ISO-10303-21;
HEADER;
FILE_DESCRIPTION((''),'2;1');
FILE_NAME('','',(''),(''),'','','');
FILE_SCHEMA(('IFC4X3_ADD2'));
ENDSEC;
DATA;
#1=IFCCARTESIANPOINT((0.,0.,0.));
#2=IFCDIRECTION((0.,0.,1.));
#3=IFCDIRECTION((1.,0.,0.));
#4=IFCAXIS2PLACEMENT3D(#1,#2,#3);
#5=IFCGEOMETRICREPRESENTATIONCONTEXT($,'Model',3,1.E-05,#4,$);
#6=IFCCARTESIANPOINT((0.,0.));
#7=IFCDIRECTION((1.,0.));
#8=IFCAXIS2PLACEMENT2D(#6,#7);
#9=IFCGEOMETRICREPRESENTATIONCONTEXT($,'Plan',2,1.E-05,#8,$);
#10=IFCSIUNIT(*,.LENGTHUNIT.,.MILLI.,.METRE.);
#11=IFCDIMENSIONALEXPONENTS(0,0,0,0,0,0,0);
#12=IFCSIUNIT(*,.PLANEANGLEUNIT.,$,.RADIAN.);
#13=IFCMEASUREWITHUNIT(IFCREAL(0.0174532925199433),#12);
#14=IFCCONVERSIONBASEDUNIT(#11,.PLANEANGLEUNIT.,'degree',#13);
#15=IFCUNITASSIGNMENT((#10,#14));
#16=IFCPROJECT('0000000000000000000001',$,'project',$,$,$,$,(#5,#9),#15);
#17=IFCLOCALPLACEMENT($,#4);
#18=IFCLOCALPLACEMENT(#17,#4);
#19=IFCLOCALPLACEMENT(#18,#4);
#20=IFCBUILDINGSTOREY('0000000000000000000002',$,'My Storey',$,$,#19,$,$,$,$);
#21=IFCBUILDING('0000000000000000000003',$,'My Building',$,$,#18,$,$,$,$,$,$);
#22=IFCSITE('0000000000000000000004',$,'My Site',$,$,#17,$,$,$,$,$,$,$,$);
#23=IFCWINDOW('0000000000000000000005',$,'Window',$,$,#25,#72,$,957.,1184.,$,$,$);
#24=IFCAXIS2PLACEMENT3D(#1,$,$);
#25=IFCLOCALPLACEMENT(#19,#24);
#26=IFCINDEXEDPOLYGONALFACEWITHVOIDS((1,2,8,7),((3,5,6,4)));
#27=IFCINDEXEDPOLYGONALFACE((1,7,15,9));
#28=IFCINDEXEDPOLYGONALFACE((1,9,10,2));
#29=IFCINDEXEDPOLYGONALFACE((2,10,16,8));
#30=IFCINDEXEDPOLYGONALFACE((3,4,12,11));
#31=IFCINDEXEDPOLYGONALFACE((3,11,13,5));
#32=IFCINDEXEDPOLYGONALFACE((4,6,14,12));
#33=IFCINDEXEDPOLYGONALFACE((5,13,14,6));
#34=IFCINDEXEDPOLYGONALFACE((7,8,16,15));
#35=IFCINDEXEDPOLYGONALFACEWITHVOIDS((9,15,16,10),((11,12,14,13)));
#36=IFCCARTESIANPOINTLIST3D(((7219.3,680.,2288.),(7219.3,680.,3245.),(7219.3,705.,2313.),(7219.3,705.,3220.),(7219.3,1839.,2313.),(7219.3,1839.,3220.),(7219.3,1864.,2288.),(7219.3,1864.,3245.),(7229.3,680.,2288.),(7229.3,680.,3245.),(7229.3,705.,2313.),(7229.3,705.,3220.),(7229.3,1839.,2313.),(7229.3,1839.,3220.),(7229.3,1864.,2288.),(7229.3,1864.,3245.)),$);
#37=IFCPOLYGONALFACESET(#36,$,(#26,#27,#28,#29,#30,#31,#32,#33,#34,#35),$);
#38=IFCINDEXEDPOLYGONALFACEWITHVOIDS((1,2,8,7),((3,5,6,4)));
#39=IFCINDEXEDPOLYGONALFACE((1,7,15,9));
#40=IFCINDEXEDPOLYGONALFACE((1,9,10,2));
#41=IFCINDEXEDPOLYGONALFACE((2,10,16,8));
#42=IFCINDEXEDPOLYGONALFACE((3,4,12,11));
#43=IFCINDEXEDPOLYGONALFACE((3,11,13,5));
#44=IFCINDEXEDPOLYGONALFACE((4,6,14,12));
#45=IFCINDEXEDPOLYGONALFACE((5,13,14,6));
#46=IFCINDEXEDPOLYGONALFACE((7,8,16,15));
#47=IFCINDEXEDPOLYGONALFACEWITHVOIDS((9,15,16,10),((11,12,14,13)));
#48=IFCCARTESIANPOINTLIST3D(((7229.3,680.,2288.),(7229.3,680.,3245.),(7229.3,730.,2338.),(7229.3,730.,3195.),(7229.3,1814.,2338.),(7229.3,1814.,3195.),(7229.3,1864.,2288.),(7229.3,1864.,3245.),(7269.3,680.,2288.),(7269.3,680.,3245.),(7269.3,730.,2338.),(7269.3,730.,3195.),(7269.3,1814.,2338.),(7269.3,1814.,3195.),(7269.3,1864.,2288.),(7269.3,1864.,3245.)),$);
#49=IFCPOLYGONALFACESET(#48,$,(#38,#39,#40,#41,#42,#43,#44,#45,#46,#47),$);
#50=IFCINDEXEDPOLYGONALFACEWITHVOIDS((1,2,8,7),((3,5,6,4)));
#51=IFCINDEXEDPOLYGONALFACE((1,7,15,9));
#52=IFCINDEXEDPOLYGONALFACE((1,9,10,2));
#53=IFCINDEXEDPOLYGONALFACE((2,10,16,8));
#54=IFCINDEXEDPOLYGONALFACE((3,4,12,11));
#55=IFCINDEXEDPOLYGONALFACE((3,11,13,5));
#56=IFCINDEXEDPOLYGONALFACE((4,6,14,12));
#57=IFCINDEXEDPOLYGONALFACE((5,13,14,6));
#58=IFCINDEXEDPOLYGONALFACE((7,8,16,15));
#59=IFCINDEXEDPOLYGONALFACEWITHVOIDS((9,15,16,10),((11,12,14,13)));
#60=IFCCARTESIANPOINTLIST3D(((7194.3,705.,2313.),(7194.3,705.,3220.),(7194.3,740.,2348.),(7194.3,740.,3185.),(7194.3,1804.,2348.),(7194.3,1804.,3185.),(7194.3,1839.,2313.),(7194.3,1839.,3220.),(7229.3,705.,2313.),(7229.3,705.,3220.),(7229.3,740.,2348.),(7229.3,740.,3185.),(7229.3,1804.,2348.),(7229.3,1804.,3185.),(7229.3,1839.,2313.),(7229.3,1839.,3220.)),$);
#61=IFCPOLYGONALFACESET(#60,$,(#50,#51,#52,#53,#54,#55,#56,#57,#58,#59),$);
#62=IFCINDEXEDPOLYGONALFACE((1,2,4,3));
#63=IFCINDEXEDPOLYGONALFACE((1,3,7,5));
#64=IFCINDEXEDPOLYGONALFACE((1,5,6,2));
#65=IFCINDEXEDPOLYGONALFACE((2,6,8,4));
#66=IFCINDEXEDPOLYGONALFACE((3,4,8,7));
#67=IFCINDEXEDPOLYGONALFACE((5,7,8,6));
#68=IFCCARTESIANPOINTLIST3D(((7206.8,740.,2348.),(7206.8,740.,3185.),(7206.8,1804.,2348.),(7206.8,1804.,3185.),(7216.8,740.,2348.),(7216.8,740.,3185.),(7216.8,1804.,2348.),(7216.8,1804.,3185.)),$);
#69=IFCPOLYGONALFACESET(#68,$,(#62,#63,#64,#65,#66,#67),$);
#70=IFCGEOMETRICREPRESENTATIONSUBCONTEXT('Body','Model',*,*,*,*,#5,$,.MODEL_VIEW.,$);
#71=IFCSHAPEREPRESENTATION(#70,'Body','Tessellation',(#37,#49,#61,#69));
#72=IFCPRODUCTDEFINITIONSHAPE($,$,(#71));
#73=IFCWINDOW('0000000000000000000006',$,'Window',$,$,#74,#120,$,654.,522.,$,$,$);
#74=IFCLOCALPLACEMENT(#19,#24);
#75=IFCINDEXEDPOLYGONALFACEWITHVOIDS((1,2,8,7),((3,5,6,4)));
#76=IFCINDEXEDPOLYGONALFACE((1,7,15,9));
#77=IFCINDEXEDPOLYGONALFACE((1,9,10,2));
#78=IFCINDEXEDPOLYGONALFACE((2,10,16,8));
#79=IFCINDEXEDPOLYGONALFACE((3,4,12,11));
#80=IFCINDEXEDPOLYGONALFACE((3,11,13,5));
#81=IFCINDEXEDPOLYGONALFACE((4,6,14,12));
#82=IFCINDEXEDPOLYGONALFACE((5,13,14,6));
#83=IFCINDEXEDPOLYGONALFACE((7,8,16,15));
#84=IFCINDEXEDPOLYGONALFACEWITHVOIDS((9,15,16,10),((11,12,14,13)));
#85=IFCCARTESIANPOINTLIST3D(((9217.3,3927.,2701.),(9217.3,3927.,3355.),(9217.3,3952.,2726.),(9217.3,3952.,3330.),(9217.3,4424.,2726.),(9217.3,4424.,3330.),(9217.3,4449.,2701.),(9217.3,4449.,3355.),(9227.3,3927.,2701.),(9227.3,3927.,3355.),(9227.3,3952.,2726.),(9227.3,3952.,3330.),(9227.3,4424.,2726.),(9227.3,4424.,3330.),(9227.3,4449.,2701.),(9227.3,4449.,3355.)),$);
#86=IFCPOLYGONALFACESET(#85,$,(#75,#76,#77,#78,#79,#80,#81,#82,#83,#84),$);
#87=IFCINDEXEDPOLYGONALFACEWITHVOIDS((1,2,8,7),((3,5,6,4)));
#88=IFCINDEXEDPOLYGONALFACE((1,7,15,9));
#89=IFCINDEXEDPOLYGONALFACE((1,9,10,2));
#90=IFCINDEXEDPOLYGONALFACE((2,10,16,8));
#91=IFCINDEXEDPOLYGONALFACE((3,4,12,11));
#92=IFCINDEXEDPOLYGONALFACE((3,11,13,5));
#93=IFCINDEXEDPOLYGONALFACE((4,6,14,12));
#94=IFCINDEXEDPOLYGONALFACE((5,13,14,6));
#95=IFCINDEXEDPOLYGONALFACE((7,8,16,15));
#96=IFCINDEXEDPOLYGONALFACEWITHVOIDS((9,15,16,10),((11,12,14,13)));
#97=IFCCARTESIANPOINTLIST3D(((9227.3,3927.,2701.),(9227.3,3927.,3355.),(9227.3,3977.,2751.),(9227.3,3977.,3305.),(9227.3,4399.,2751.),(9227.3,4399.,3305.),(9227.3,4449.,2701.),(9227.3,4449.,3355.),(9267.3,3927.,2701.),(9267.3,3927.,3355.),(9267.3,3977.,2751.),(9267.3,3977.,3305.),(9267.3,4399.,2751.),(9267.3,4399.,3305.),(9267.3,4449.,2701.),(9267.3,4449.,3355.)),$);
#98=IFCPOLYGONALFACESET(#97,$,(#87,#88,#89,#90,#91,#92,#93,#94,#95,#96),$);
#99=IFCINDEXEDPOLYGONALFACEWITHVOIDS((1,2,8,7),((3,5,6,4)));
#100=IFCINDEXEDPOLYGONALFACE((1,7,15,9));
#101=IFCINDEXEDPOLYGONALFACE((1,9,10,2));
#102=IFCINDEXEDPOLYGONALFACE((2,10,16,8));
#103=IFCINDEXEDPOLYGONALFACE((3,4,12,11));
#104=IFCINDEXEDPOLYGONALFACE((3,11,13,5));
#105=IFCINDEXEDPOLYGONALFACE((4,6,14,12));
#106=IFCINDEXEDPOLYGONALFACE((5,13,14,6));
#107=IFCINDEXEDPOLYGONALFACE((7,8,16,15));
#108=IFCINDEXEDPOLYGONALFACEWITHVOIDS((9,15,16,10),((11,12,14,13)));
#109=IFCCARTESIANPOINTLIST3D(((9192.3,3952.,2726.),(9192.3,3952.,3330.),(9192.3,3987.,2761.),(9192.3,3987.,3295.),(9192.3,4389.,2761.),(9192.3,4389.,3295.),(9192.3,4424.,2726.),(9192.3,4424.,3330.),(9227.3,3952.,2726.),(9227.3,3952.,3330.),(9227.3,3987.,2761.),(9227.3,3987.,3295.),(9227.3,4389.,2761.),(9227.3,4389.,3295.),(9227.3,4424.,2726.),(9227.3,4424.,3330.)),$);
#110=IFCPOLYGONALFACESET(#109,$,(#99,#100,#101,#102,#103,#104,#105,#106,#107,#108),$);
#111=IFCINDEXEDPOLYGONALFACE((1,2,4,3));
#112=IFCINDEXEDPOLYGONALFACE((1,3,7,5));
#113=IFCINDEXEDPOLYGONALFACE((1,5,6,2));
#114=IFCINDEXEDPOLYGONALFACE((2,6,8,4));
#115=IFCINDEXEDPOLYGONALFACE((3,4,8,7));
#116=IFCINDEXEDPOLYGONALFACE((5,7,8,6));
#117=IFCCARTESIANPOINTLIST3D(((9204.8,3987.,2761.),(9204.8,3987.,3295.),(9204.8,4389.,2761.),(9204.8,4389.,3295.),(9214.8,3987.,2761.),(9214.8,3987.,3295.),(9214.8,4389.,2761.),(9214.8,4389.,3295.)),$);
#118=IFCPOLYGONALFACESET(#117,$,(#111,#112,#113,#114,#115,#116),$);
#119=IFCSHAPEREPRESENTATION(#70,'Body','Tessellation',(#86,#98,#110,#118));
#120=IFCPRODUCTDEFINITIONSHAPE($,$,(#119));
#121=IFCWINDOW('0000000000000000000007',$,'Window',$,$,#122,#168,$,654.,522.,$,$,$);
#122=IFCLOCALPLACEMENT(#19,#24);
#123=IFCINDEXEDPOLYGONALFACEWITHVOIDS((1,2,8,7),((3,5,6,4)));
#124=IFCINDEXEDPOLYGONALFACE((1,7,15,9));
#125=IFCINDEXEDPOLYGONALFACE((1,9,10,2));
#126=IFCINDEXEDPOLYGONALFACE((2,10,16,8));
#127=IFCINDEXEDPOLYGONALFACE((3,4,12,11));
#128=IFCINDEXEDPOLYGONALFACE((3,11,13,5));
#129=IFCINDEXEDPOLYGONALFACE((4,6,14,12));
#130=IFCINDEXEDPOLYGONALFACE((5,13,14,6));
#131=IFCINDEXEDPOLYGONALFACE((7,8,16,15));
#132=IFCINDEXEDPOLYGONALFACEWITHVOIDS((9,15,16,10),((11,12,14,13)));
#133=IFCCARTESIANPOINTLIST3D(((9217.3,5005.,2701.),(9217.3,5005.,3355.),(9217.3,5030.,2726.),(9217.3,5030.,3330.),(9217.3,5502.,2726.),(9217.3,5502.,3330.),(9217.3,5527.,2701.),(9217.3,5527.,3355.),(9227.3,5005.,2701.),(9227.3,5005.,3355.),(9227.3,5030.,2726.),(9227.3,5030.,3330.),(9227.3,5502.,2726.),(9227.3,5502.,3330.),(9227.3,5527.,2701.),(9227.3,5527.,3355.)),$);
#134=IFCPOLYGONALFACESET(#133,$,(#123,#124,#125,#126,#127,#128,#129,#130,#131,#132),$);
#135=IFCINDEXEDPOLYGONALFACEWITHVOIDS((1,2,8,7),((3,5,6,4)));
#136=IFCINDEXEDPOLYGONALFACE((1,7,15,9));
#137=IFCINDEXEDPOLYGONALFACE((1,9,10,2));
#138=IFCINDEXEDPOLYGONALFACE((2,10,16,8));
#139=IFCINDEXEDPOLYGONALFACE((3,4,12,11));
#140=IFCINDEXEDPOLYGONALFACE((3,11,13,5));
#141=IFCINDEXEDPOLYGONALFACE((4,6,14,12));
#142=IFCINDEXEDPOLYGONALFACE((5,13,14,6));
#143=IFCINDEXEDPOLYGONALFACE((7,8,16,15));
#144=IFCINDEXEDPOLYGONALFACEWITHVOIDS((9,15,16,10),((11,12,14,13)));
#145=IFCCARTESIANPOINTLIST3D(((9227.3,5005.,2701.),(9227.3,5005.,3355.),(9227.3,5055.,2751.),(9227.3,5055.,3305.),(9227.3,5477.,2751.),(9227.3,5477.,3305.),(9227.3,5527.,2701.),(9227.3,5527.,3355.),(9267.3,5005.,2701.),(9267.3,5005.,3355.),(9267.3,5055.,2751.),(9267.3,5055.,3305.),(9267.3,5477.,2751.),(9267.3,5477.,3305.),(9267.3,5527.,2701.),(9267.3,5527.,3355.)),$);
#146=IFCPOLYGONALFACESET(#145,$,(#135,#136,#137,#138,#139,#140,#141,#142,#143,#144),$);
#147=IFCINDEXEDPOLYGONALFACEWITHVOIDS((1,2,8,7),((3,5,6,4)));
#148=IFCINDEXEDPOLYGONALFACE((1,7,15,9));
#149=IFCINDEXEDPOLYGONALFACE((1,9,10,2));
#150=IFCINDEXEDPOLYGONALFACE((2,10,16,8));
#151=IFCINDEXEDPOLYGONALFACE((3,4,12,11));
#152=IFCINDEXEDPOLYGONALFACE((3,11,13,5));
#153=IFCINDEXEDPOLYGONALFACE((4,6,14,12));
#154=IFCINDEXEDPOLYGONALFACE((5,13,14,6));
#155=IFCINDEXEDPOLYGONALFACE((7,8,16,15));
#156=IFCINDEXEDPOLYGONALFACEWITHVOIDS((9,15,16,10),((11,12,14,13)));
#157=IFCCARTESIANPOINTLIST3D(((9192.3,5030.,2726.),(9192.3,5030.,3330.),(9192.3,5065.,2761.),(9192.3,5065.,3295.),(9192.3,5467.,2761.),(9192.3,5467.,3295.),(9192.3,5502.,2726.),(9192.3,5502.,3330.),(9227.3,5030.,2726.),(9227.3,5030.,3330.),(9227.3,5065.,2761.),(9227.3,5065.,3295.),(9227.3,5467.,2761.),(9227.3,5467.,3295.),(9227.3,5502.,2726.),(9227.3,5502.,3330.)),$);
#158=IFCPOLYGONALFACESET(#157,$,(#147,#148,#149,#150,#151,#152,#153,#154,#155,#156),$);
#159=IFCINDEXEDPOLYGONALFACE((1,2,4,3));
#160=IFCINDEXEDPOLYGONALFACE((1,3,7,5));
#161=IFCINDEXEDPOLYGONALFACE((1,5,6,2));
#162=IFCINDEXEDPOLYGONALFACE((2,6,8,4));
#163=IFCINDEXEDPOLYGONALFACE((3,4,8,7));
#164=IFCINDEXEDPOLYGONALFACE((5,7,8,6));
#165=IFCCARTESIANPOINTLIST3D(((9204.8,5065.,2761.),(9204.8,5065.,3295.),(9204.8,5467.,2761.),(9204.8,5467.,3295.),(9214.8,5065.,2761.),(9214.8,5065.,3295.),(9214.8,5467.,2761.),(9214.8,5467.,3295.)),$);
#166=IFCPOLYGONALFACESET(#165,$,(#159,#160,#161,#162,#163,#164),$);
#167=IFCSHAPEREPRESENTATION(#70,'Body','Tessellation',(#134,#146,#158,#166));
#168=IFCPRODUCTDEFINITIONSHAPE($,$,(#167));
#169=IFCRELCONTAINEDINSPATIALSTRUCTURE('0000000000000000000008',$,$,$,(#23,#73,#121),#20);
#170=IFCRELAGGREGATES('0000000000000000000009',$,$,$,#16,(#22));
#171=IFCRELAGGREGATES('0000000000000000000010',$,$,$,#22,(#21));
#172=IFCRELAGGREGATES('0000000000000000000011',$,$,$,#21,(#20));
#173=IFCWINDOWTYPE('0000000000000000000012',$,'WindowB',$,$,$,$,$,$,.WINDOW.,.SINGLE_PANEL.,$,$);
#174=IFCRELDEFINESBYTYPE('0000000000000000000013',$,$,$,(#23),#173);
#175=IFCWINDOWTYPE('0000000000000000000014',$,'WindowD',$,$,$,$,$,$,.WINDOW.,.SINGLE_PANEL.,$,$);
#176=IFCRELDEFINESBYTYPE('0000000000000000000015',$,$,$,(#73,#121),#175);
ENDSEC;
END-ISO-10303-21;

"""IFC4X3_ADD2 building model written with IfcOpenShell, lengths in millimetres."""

from ifc_helpers import new_model, entity, si_unit, converted_unit, frame, origin_with_axes, origin_2d_with_axis, place, context, subcontext, project, spatial, line, indexed_curve, outline, extrude, shape, source, transform, mapped, type_object, type_shapes, element, save


model = new_model("IFC4X3_ADD2")

# Units and contexts
model_context = context("Model", 3, precision=1e-05, world=origin_with_axes())
plan_context = context("Plan", 2, precision=1e-05, world=origin_2d_with_axis())
body_context_1 = subcontext(model_context, "Body", "Model", "MODEL_VIEW")
body_context_2 = subcontext(plan_context, "Body", "Plan", "PLAN_VIEW")
ifc_project = project(units=[si_unit("LENGTHUNIT", "METRE", prefix="MILLI"), converted_unit("PLANEANGLEUNIT", "degree", entity("IfcReal", 0.0174532925199433), si_unit("PLANEANGLEUNIT", "RADIAN"), dimensions=[0, 0, 0, 0, 0, 0, 0])], contexts=[model_context, plan_context])

# Site, building, storey
site_placement = place(None, origin_with_axes())
site = spatial("IfcSite", under=ifc_project, at=site_placement, Name="My Site")
building_placement = place(site_placement, origin_with_axes())
building = spatial("IfcBuilding", under=site, at=building_placement, Name="My Building")
storey_placement = place(building_placement, origin_with_axes())
storey = spatial("IfcBuildingStorey", under=building, at=storey_placement, Name="My Storey")

# Windows
window_type_1 = type_object("IfcWindowType", Name="WindowB", PartitioningType="SINGLE_PANEL", PredefinedType="WINDOW")
shared_shape_1 = source(origin_with_axes(), body_context_1, "Body", "SweptSolid", [
    extrude(outline(indexed_curve([(0.0, 0.0), (1184.0, 0.0), (1184.0, 957.0), (0.0, 957.0)], segments=[line(1, 2, 3, 4, 1)]), holes=[indexed_curve([(25.0, 25.0), (1159.0, 25.0), (1159.0, 932.0), (25.0, 932.0)], segments=[line(1, 2, 3, 4, 1)])]), frame((0.0, 90.0, 0.0), z_axis=(0.0, -1.0, 0.0), x_axis=(1.0, 0.0, 0.0)), (0.0, 0.0, -1.0), 10.0),
    extrude(outline(indexed_curve([(0.0, 0.0), (1184.0, 0.0), (1184.0, 957.0), (0.0, 957.0)], segments=[line(1, 2, 3, 4, 1)]), holes=[indexed_curve([(50.0, 50.0), (1134.0, 50.0), (1134.0, 907.0), (50.0, 907.0)], segments=[line(1, 2, 3, 4, 1)])]), frame((0.0, 50.0, 0.0), z_axis=(0.0, -1.0, 0.0), x_axis=(1.0, 0.0, 0.0)), (0.0, 0.0, -1.0), 40.0),
    extrude(outline(indexed_curve([(0.0, 0.0), (1134.0, 0.0), (1134.0, 907.0), (0.0, 907.0)], segments=[line(1, 2, 3, 4, 1)]), holes=[indexed_curve([(35.0, 35.0), (1099.0, 35.0), (1099.0, 872.0), (35.0, 872.0)], segments=[line(1, 2, 3, 4, 1)])]), frame((25.0, 90.0, 25.0), z_axis=(0.0, -1.0, 0.0), x_axis=(1.0, 0.0, 0.0)), (0.0, 0.0, -1.0), 35.0),
    extrude(outline(indexed_curve([(35.0, 35.0), (1099.0, 35.0), (1099.0, 872.0), (35.0, 872.0)], segments=[line(1, 2, 3, 4, 1)])), frame((25.0, 102.5, 25.0), z_axis=(0.0, -1.0, 0.0), x_axis=(1.0, 0.0, 0.0)), (0.0, 0.0, -1.0), 10.0),
])
shared_shape_2 = source(origin_with_axes(), body_context_2, "Body", "Curve2D", [
    entity("IfcIndexedPolyCurve", entity("IfcCartesianPointList2D", [[50.0, 50.0], [1134.0, 50.0]])),
    entity("IfcIndexedPolyCurve", entity("IfcCartesianPointList2D", [[0.0, 100.0], [25.0, 100.0], [25.0, 90.0], [50.0, 90.0], [50.0, 50.0], [0.0, 50.0]]), [entity("IfcLineIndex", [1, 2, 3, 4, 5, 6, 1])]),
    entity("IfcIndexedPolyCurve", entity("IfcCartesianPointList2D", [[1184.0, 100.0], [1159.0, 100.0], [1159.0, 90.0], [1134.0, 90.0], [1134.0, 50.0], [1184.0, 50.0]]), [entity("IfcLineIndex", [1, 2, 3, 4, 5, 6, 1])]),
    entity("IfcIndexedPolyCurve", entity("IfcCartesianPointList2D", [[25.0, 90.0], [60.0, 90.0], [60.0, 125.0], [25.0, 125.0]]), [entity("IfcLineIndex", [1, 2, 3, 4, 1])]),
    entity("IfcIndexedPolyCurve", entity("IfcCartesianPointList2D", [[1159.0, 90.0], [1124.0, 90.0], [1124.0, 125.0], [1159.0, 125.0]]), [entity("IfcLineIndex", [1, 2, 3, 4, 1])]),
    entity("IfcIndexedPolyCurve", entity("IfcCartesianPointList2D", [[60.0, 90.0], [1124.0, 90.0]])),
    entity("IfcIndexedPolyCurve", entity("IfcCartesianPointList2D", [[60.0, 125.0], [1124.0, 125.0]])),
    entity("IfcIndexedPolyCurve", entity("IfcCartesianPointList2D", [[60.0, 107.5], [1124.0, 107.5]])),
])
type_shapes(window_type_1, [shared_shape_1, shared_shape_2])
window_placement = place(storey_placement, frame((7319.3, 680.0, 2288.0), z_axis=(0.0, 0.0, 1.0), x_axis=(0.0, 1.0, 0.0)))
element("IfcWindow", 1, at=window_placement, inside=storey, type_object=window_type_1, Name="Window", OverallHeight=957.0, OverallWidth=1184.0, shapes=[
    shape(body_context_1, "Body", "MappedRepresentation", [mapped(shared_shape_1, transform((0.0, 0.0, 0.0), x_axis=(1.0, 0.0, 0.0), y_axis=(0.0, 1.0, 0.0), z_axis=(0.0, 0.0, 1.0), scale=1.0))]),
    shape(body_context_2, "Body", "MappedRepresentation", [mapped(shared_shape_2, transform((0.0, 0.0, 0.0), x_axis=(1.0, 0.0, 0.0), y_axis=(0.0, 1.0, 0.0), z_axis=(0.0, 0.0, 1.0), scale=1.0))]),
])
window_type_2 = type_object("IfcWindowType", Name="WindowD", PartitioningType="SINGLE_PANEL", PredefinedType="WINDOW")
shared_shape_3 = source(origin_with_axes(), body_context_1, "Body", "SweptSolid", [
    extrude(outline(indexed_curve([(0.0, 0.0), (522.0, 0.0), (522.0, 654.0), (0.0, 654.0)], segments=[line(1, 2, 3, 4, 1)]), holes=[indexed_curve([(25.0, 25.0), (497.0, 25.0), (497.0, 629.0), (25.0, 629.0)], segments=[line(1, 2, 3, 4, 1)])]), frame((0.0, 90.0, 0.0), z_axis=(0.0, -1.0, 0.0), x_axis=(1.0, 0.0, 0.0)), (0.0, 0.0, -1.0), 10.0),
    extrude(outline(indexed_curve([(0.0, 0.0), (522.0, 0.0), (522.0, 654.0), (0.0, 654.0)], segments=[line(1, 2, 3, 4, 1)]), holes=[indexed_curve([(50.0, 50.0), (472.0, 50.0), (472.0, 604.0), (50.0, 604.0)], segments=[line(1, 2, 3, 4, 1)])]), frame((0.0, 50.0, 0.0), z_axis=(0.0, -1.0, 0.0), x_axis=(1.0, 0.0, 0.0)), (0.0, 0.0, -1.0), 40.0),
    extrude(outline(indexed_curve([(0.0, 0.0), (472.0, 0.0), (472.0, 604.0), (0.0, 604.0)], segments=[line(1, 2, 3, 4, 1)]), holes=[indexed_curve([(35.0, 35.0), (437.0, 35.0), (437.0, 569.0), (35.0, 569.0)], segments=[line(1, 2, 3, 4, 1)])]), frame((25.0, 90.0, 25.0), z_axis=(0.0, -1.0, 0.0), x_axis=(1.0, 0.0, 0.0)), (0.0, 0.0, -1.0), 35.0),
    extrude(outline(indexed_curve([(35.0, 35.0), (437.0, 35.0), (437.0, 569.0), (35.0, 569.0)], segments=[line(1, 2, 3, 4, 1)])), frame((25.0, 102.5, 25.0), z_axis=(0.0, -1.0, 0.0), x_axis=(1.0, 0.0, 0.0)), (0.0, 0.0, -1.0), 10.0),
])
shared_shape_4 = source(origin_with_axes(), body_context_2, "Body", "Curve2D", [
    entity("IfcIndexedPolyCurve", entity("IfcCartesianPointList2D", [[50.0, 50.0], [472.0, 50.0]])),
    entity("IfcIndexedPolyCurve", entity("IfcCartesianPointList2D", [[0.0, 100.0], [25.0, 100.0], [25.0, 90.0], [50.0, 90.0], [50.0, 50.0], [0.0, 50.0]]), [entity("IfcLineIndex", [1, 2, 3, 4, 5, 6, 1])]),
    entity("IfcIndexedPolyCurve", entity("IfcCartesianPointList2D", [[522.0, 100.0], [497.0, 100.0], [497.0, 90.0], [472.0, 90.0], [472.0, 50.0], [522.0, 50.0]]), [entity("IfcLineIndex", [1, 2, 3, 4, 5, 6, 1])]),
    entity("IfcIndexedPolyCurve", entity("IfcCartesianPointList2D", [[25.0, 90.0], [60.0, 90.0], [60.0, 125.0], [25.0, 125.0]]), [entity("IfcLineIndex", [1, 2, 3, 4, 1])]),
    entity("IfcIndexedPolyCurve", entity("IfcCartesianPointList2D", [[497.0, 90.0], [462.0, 90.0], [462.0, 125.0], [497.0, 125.0]]), [entity("IfcLineIndex", [1, 2, 3, 4, 1])]),
    entity("IfcIndexedPolyCurve", entity("IfcCartesianPointList2D", [[60.0, 90.0], [462.0, 90.0]])),
    entity("IfcIndexedPolyCurve", entity("IfcCartesianPointList2D", [[60.0, 125.0], [462.0, 125.0]])),
    entity("IfcIndexedPolyCurve", entity("IfcCartesianPointList2D", [[60.0, 107.5], [462.0, 107.5]])),
])
type_shapes(window_type_2, [shared_shape_3, shared_shape_4])
for number, where, z_axis, x_axis, name in (
    (2, (9317.3, 3927.0, 2701.0), (0.0, 0.0, 1.0), (0.0, 1.0, 0.0), "Window"),
    (3, (9317.3, 5005.0, 2701.0), (0.0, 0.0, 1.0), (0.0, 1.0, 0.0), "Window"),
):
    element("IfcWindow", number, at=place(storey_placement, frame(where, z_axis=z_axis, x_axis=x_axis)), inside=storey, type_object=window_type_2, Name=name, OverallHeight=654.0, OverallWidth=522.0, shapes=[
        shape(body_context_1, "Body", "MappedRepresentation", [mapped(shared_shape_3, transform((0.0, 0.0, 0.0), x_axis=(1.0, 0.0, 0.0), y_axis=(0.0, 1.0, 0.0), z_axis=(0.0, 0.0, 1.0), scale=1.0))]),
        shape(body_context_2, "Body", "MappedRepresentation", [mapped(shared_shape_4, transform((0.0, 0.0, 0.0), x_axis=(1.0, 0.0, 0.0), y_axis=(0.0, 1.0, 0.0), z_axis=(0.0, 0.0, 1.0), scale=1.0))]),
    ])

save(model, "model.ifc")
